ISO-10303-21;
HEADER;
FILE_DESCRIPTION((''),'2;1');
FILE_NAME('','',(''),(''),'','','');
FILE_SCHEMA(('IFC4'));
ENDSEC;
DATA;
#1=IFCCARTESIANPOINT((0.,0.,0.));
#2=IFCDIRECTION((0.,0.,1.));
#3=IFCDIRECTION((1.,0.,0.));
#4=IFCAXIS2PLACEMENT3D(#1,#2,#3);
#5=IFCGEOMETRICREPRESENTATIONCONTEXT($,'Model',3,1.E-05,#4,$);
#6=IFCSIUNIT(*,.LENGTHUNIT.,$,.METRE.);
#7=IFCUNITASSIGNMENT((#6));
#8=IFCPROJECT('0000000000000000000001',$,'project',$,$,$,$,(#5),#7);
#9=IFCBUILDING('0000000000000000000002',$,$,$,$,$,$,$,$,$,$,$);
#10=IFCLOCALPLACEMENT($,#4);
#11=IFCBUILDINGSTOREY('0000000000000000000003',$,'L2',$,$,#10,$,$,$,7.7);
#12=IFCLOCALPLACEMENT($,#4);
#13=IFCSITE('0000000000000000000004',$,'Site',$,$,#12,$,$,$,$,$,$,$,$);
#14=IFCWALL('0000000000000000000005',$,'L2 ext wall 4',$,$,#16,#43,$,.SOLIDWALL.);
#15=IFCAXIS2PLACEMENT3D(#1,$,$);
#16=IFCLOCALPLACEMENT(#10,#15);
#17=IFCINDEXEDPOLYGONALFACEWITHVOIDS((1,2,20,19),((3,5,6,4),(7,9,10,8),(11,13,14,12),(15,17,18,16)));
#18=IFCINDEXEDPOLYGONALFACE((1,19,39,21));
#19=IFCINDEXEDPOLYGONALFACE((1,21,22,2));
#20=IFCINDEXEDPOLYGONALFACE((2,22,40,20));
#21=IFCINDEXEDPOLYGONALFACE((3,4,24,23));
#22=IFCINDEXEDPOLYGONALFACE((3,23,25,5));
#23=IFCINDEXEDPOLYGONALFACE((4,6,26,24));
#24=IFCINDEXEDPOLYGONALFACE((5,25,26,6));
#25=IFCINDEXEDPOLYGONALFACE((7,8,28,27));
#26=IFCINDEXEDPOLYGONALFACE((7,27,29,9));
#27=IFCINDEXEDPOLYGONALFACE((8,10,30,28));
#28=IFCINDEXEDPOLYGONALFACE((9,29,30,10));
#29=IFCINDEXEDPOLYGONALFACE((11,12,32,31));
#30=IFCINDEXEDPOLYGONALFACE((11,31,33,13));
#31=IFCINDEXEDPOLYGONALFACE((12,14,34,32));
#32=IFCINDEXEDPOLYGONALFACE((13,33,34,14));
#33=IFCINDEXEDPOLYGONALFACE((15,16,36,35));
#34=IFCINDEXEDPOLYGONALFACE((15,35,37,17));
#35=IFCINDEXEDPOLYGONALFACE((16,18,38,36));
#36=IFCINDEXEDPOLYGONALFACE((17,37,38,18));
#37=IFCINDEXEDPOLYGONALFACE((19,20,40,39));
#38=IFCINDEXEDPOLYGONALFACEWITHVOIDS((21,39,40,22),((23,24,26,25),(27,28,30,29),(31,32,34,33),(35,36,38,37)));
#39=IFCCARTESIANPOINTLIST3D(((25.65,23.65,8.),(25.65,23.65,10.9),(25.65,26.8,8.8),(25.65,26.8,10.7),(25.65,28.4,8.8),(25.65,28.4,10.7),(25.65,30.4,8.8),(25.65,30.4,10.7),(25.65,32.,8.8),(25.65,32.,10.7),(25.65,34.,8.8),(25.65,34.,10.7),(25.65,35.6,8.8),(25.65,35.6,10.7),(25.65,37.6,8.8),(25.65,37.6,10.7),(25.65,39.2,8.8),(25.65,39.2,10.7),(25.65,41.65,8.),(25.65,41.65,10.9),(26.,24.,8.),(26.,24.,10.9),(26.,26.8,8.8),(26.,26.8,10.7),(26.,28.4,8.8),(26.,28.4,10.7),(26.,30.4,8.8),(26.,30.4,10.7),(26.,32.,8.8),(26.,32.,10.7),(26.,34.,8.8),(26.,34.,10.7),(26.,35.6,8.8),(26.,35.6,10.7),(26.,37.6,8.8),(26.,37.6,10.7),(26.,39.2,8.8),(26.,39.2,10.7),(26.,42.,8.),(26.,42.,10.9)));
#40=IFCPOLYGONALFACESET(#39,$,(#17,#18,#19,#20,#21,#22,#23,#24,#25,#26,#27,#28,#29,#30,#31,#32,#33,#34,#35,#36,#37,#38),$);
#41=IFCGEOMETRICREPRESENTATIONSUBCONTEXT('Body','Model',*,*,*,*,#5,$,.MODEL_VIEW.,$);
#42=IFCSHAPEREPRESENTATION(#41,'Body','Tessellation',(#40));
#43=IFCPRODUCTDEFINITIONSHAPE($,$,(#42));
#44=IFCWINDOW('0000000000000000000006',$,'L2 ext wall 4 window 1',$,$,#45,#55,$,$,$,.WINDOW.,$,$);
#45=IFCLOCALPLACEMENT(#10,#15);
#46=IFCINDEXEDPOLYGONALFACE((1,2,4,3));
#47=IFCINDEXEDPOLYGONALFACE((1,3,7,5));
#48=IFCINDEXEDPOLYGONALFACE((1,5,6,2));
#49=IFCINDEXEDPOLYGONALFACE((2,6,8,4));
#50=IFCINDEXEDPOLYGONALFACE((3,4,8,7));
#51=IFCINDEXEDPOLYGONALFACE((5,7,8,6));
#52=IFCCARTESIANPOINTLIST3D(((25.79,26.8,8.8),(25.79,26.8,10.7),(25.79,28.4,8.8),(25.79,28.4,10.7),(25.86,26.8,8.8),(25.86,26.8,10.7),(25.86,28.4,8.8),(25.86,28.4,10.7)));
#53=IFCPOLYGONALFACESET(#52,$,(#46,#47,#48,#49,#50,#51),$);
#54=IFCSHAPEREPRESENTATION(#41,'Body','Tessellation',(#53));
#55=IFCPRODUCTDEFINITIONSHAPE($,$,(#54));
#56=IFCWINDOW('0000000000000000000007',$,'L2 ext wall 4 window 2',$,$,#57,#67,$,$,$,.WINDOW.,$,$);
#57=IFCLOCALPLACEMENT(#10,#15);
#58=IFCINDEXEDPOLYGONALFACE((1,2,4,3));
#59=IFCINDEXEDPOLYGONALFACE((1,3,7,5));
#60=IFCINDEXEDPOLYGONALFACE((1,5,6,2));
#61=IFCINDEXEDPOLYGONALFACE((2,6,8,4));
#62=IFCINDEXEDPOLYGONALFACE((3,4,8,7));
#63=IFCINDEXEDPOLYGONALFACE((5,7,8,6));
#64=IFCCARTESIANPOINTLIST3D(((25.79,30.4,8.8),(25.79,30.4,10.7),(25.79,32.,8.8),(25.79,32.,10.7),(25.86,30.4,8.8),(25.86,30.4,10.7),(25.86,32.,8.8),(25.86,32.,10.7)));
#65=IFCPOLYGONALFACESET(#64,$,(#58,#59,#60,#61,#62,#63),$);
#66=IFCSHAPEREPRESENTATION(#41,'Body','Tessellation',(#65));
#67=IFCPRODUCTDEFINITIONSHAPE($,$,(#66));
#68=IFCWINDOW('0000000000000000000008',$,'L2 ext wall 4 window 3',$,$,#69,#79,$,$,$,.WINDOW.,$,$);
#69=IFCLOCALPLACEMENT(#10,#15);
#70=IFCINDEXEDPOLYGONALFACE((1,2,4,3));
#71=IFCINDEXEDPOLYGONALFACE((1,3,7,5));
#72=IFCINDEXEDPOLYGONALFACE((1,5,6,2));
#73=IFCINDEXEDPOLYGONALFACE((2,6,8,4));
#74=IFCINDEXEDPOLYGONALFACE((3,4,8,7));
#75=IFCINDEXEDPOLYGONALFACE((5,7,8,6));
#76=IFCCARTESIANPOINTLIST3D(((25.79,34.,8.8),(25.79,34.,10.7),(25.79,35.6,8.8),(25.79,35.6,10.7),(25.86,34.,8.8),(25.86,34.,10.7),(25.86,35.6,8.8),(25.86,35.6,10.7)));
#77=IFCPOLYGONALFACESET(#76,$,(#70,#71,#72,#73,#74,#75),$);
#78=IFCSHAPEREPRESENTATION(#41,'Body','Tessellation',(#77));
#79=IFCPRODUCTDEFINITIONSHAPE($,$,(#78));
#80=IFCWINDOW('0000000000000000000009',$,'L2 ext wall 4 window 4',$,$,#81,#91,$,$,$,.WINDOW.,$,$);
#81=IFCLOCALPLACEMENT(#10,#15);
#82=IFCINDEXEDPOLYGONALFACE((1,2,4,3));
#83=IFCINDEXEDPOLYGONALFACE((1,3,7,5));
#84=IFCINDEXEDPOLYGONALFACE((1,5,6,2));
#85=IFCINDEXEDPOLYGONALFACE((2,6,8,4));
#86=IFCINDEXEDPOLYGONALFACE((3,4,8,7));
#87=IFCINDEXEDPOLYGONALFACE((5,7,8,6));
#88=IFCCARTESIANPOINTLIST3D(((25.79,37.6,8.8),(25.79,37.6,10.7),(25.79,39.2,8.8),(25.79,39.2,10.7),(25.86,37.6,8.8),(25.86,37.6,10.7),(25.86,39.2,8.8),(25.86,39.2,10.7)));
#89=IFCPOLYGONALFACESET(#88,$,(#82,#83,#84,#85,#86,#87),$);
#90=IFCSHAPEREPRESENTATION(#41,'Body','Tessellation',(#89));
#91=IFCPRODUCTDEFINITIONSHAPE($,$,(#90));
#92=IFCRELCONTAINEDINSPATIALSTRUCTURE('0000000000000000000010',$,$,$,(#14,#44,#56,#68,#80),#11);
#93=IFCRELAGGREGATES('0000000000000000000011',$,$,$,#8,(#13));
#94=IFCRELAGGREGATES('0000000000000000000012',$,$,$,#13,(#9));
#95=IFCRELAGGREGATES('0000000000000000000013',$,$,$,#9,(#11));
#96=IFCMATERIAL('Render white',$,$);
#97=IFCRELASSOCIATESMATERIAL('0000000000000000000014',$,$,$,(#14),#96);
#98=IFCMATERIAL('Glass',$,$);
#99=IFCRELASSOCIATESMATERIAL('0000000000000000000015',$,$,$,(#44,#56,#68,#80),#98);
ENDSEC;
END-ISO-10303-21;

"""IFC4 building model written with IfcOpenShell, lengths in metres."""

from ifc_helpers import new_model, si_unit, frame, origin_with_axes, place, context, subcontext, project, spatial, polyline, outline, extrude, material, element, fill, save


model = new_model("IFC4")

# Units and contexts
model_context = context("Model", 3, precision=1e-05, world=origin_with_axes())
body_context = subcontext(model_context, "Body", "Model", "MODEL_VIEW")
ifc_project = project(units=[si_unit("LENGTHUNIT", "METRE")], contexts=[model_context])

# Site, building, storey
site_placement = place(None, origin_with_axes())
site = spatial("IfcSite", under=ifc_project, at=site_placement, Name="Site")
building = spatial("IfcBuilding", under=site)
storey_placement = place(None, origin_with_axes())
storey = spatial("IfcBuildingStorey", under=building, at=storey_placement, Name="L2", Elevation=7.7)

# Wall, openings, windows
ifc_material_1 = material(Name="Render white")
ifc_material_2 = material(Name="Glass")
wall_1_placement = place(storey_placement, origin_with_axes())
wall_1 = element("IfcWall", 1, at=wall_1_placement, inside=storey, material=ifc_material_1, Name="L2 ext wall 4", PredefinedType="SOLIDWALL", context=body_context, shape_type="SweptSolid", body=[
    extrude(outline(polyline([(26.0, 24.0), (26.0, 42.0), (25.65, 41.65), (25.65, 23.65), (26.0, 24.0)])), frame((0.0, 0.0, 8.0), z_axis=(0.0, 0.0, 1.0), x_axis=(1.0, 0.0, 0.0)), (0.0, 0.0, 1.0), 2.9),
])
opening_1_placement = place(wall_1_placement, origin_with_axes())
opening_1 = element("IfcOpeningElement", 2, at=opening_1_placement, cuts=wall_1, context=body_context, shape_type="SweptSolid", body=[
    extrude(outline(polyline([(26.05, 26.8), (26.05, 28.4), (25.6, 28.4), (25.6, 26.8), (26.05, 26.8)])), frame((0.0, 0.0, 8.8), z_axis=(0.0, 0.0, 1.0), x_axis=(1.0, 0.0, 0.0)), (0.0, 0.0, 1.0), 1.9),
])
opening_2_placement = place(wall_1_placement, origin_with_axes())
opening_2 = element("IfcOpeningElement", 3, at=opening_2_placement, cuts=wall_1, context=body_context, shape_type="SweptSolid", body=[
    extrude(outline(polyline([(26.05, 30.4), (26.05, 32.0), (25.6, 32.0), (25.6, 30.4), (26.05, 30.4)])), frame((0.0, 0.0, 8.8), z_axis=(0.0, 0.0, 1.0), x_axis=(1.0, 0.0, 0.0)), (0.0, 0.0, 1.0), 1.9),
])
opening_3_placement = place(wall_1_placement, origin_with_axes())
opening_3 = element("IfcOpeningElement", 4, at=opening_3_placement, cuts=wall_1, context=body_context, shape_type="SweptSolid", body=[
    extrude(outline(polyline([(26.05, 34.0), (26.05, 35.6), (25.6, 35.6), (25.6, 34.0), (26.05, 34.0)])), frame((0.0, 0.0, 8.8), z_axis=(0.0, 0.0, 1.0), x_axis=(1.0, 0.0, 0.0)), (0.0, 0.0, 1.0), 1.9),
])
opening_4_placement = place(wall_1_placement, origin_with_axes())
opening_4 = element("IfcOpeningElement", 5, at=opening_4_placement, cuts=wall_1, context=body_context, shape_type="SweptSolid", body=[
    extrude(outline(polyline([(26.05, 37.6), (26.05, 39.2), (25.6, 39.2), (25.6, 37.6), (26.05, 37.6)])), frame((0.0, 0.0, 8.8), z_axis=(0.0, 0.0, 1.0), x_axis=(1.0, 0.0, 0.0)), (0.0, 0.0, 1.0), 1.9),
])
window_1_placement = place(storey_placement, origin_with_axes())
window_1 = element("IfcWindow", 6, at=window_1_placement, inside=storey, material=ifc_material_2, Name="L2 ext wall 4 window 1", PredefinedType="WINDOW", context=body_context, shape_type="SweptSolid", body=[
    extrude(outline(polyline([(25.86, 26.8), (25.86, 28.4), (25.79, 28.4), (25.79, 26.8), (25.86, 26.8)])), frame((0.0, 0.0, 8.8), z_axis=(0.0, 0.0, 1.0), x_axis=(1.0, 0.0, 0.0)), (0.0, 0.0, 1.0), 1.9),
])
fill(opening_1, window_1)
window_2_placement = place(storey_placement, origin_with_axes())
window_2 = element("IfcWindow", 7, at=window_2_placement, inside=storey, material=ifc_material_2, Name="L2 ext wall 4 window 2", PredefinedType="WINDOW", context=body_context, shape_type="SweptSolid", body=[
    extrude(outline(polyline([(25.86, 30.4), (25.86, 32.0), (25.79, 32.0), (25.79, 30.4), (25.86, 30.4)])), frame((0.0, 0.0, 8.8), z_axis=(0.0, 0.0, 1.0), x_axis=(1.0, 0.0, 0.0)), (0.0, 0.0, 1.0), 1.9),
])
fill(opening_2, window_2)
window_3_placement = place(storey_placement, origin_with_axes())
window_3 = element("IfcWindow", 8, at=window_3_placement, inside=storey, material=ifc_material_2, Name="L2 ext wall 4 window 3", PredefinedType="WINDOW", context=body_context, shape_type="SweptSolid", body=[
    extrude(outline(polyline([(25.86, 34.0), (25.86, 35.6), (25.79, 35.6), (25.79, 34.0), (25.86, 34.0)])), frame((0.0, 0.0, 8.8), z_axis=(0.0, 0.0, 1.0), x_axis=(1.0, 0.0, 0.0)), (0.0, 0.0, 1.0), 1.9),
])
fill(opening_3, window_3)
window_4_placement = place(storey_placement, origin_with_axes())
window_4 = element("IfcWindow", 9, at=window_4_placement, inside=storey, material=ifc_material_2, Name="L2 ext wall 4 window 4", PredefinedType="WINDOW", context=body_context, shape_type="SweptSolid", body=[
    extrude(outline(polyline([(25.86, 37.6), (25.86, 39.2), (25.79, 39.2), (25.79, 37.6), (25.86, 37.6)])), frame((0.0, 0.0, 8.8), z_axis=(0.0, 0.0, 1.0), x_axis=(1.0, 0.0, 0.0)), (0.0, 0.0, 1.0), 1.9),
])
fill(opening_4, window_4)

save(model, "model.ifc")
